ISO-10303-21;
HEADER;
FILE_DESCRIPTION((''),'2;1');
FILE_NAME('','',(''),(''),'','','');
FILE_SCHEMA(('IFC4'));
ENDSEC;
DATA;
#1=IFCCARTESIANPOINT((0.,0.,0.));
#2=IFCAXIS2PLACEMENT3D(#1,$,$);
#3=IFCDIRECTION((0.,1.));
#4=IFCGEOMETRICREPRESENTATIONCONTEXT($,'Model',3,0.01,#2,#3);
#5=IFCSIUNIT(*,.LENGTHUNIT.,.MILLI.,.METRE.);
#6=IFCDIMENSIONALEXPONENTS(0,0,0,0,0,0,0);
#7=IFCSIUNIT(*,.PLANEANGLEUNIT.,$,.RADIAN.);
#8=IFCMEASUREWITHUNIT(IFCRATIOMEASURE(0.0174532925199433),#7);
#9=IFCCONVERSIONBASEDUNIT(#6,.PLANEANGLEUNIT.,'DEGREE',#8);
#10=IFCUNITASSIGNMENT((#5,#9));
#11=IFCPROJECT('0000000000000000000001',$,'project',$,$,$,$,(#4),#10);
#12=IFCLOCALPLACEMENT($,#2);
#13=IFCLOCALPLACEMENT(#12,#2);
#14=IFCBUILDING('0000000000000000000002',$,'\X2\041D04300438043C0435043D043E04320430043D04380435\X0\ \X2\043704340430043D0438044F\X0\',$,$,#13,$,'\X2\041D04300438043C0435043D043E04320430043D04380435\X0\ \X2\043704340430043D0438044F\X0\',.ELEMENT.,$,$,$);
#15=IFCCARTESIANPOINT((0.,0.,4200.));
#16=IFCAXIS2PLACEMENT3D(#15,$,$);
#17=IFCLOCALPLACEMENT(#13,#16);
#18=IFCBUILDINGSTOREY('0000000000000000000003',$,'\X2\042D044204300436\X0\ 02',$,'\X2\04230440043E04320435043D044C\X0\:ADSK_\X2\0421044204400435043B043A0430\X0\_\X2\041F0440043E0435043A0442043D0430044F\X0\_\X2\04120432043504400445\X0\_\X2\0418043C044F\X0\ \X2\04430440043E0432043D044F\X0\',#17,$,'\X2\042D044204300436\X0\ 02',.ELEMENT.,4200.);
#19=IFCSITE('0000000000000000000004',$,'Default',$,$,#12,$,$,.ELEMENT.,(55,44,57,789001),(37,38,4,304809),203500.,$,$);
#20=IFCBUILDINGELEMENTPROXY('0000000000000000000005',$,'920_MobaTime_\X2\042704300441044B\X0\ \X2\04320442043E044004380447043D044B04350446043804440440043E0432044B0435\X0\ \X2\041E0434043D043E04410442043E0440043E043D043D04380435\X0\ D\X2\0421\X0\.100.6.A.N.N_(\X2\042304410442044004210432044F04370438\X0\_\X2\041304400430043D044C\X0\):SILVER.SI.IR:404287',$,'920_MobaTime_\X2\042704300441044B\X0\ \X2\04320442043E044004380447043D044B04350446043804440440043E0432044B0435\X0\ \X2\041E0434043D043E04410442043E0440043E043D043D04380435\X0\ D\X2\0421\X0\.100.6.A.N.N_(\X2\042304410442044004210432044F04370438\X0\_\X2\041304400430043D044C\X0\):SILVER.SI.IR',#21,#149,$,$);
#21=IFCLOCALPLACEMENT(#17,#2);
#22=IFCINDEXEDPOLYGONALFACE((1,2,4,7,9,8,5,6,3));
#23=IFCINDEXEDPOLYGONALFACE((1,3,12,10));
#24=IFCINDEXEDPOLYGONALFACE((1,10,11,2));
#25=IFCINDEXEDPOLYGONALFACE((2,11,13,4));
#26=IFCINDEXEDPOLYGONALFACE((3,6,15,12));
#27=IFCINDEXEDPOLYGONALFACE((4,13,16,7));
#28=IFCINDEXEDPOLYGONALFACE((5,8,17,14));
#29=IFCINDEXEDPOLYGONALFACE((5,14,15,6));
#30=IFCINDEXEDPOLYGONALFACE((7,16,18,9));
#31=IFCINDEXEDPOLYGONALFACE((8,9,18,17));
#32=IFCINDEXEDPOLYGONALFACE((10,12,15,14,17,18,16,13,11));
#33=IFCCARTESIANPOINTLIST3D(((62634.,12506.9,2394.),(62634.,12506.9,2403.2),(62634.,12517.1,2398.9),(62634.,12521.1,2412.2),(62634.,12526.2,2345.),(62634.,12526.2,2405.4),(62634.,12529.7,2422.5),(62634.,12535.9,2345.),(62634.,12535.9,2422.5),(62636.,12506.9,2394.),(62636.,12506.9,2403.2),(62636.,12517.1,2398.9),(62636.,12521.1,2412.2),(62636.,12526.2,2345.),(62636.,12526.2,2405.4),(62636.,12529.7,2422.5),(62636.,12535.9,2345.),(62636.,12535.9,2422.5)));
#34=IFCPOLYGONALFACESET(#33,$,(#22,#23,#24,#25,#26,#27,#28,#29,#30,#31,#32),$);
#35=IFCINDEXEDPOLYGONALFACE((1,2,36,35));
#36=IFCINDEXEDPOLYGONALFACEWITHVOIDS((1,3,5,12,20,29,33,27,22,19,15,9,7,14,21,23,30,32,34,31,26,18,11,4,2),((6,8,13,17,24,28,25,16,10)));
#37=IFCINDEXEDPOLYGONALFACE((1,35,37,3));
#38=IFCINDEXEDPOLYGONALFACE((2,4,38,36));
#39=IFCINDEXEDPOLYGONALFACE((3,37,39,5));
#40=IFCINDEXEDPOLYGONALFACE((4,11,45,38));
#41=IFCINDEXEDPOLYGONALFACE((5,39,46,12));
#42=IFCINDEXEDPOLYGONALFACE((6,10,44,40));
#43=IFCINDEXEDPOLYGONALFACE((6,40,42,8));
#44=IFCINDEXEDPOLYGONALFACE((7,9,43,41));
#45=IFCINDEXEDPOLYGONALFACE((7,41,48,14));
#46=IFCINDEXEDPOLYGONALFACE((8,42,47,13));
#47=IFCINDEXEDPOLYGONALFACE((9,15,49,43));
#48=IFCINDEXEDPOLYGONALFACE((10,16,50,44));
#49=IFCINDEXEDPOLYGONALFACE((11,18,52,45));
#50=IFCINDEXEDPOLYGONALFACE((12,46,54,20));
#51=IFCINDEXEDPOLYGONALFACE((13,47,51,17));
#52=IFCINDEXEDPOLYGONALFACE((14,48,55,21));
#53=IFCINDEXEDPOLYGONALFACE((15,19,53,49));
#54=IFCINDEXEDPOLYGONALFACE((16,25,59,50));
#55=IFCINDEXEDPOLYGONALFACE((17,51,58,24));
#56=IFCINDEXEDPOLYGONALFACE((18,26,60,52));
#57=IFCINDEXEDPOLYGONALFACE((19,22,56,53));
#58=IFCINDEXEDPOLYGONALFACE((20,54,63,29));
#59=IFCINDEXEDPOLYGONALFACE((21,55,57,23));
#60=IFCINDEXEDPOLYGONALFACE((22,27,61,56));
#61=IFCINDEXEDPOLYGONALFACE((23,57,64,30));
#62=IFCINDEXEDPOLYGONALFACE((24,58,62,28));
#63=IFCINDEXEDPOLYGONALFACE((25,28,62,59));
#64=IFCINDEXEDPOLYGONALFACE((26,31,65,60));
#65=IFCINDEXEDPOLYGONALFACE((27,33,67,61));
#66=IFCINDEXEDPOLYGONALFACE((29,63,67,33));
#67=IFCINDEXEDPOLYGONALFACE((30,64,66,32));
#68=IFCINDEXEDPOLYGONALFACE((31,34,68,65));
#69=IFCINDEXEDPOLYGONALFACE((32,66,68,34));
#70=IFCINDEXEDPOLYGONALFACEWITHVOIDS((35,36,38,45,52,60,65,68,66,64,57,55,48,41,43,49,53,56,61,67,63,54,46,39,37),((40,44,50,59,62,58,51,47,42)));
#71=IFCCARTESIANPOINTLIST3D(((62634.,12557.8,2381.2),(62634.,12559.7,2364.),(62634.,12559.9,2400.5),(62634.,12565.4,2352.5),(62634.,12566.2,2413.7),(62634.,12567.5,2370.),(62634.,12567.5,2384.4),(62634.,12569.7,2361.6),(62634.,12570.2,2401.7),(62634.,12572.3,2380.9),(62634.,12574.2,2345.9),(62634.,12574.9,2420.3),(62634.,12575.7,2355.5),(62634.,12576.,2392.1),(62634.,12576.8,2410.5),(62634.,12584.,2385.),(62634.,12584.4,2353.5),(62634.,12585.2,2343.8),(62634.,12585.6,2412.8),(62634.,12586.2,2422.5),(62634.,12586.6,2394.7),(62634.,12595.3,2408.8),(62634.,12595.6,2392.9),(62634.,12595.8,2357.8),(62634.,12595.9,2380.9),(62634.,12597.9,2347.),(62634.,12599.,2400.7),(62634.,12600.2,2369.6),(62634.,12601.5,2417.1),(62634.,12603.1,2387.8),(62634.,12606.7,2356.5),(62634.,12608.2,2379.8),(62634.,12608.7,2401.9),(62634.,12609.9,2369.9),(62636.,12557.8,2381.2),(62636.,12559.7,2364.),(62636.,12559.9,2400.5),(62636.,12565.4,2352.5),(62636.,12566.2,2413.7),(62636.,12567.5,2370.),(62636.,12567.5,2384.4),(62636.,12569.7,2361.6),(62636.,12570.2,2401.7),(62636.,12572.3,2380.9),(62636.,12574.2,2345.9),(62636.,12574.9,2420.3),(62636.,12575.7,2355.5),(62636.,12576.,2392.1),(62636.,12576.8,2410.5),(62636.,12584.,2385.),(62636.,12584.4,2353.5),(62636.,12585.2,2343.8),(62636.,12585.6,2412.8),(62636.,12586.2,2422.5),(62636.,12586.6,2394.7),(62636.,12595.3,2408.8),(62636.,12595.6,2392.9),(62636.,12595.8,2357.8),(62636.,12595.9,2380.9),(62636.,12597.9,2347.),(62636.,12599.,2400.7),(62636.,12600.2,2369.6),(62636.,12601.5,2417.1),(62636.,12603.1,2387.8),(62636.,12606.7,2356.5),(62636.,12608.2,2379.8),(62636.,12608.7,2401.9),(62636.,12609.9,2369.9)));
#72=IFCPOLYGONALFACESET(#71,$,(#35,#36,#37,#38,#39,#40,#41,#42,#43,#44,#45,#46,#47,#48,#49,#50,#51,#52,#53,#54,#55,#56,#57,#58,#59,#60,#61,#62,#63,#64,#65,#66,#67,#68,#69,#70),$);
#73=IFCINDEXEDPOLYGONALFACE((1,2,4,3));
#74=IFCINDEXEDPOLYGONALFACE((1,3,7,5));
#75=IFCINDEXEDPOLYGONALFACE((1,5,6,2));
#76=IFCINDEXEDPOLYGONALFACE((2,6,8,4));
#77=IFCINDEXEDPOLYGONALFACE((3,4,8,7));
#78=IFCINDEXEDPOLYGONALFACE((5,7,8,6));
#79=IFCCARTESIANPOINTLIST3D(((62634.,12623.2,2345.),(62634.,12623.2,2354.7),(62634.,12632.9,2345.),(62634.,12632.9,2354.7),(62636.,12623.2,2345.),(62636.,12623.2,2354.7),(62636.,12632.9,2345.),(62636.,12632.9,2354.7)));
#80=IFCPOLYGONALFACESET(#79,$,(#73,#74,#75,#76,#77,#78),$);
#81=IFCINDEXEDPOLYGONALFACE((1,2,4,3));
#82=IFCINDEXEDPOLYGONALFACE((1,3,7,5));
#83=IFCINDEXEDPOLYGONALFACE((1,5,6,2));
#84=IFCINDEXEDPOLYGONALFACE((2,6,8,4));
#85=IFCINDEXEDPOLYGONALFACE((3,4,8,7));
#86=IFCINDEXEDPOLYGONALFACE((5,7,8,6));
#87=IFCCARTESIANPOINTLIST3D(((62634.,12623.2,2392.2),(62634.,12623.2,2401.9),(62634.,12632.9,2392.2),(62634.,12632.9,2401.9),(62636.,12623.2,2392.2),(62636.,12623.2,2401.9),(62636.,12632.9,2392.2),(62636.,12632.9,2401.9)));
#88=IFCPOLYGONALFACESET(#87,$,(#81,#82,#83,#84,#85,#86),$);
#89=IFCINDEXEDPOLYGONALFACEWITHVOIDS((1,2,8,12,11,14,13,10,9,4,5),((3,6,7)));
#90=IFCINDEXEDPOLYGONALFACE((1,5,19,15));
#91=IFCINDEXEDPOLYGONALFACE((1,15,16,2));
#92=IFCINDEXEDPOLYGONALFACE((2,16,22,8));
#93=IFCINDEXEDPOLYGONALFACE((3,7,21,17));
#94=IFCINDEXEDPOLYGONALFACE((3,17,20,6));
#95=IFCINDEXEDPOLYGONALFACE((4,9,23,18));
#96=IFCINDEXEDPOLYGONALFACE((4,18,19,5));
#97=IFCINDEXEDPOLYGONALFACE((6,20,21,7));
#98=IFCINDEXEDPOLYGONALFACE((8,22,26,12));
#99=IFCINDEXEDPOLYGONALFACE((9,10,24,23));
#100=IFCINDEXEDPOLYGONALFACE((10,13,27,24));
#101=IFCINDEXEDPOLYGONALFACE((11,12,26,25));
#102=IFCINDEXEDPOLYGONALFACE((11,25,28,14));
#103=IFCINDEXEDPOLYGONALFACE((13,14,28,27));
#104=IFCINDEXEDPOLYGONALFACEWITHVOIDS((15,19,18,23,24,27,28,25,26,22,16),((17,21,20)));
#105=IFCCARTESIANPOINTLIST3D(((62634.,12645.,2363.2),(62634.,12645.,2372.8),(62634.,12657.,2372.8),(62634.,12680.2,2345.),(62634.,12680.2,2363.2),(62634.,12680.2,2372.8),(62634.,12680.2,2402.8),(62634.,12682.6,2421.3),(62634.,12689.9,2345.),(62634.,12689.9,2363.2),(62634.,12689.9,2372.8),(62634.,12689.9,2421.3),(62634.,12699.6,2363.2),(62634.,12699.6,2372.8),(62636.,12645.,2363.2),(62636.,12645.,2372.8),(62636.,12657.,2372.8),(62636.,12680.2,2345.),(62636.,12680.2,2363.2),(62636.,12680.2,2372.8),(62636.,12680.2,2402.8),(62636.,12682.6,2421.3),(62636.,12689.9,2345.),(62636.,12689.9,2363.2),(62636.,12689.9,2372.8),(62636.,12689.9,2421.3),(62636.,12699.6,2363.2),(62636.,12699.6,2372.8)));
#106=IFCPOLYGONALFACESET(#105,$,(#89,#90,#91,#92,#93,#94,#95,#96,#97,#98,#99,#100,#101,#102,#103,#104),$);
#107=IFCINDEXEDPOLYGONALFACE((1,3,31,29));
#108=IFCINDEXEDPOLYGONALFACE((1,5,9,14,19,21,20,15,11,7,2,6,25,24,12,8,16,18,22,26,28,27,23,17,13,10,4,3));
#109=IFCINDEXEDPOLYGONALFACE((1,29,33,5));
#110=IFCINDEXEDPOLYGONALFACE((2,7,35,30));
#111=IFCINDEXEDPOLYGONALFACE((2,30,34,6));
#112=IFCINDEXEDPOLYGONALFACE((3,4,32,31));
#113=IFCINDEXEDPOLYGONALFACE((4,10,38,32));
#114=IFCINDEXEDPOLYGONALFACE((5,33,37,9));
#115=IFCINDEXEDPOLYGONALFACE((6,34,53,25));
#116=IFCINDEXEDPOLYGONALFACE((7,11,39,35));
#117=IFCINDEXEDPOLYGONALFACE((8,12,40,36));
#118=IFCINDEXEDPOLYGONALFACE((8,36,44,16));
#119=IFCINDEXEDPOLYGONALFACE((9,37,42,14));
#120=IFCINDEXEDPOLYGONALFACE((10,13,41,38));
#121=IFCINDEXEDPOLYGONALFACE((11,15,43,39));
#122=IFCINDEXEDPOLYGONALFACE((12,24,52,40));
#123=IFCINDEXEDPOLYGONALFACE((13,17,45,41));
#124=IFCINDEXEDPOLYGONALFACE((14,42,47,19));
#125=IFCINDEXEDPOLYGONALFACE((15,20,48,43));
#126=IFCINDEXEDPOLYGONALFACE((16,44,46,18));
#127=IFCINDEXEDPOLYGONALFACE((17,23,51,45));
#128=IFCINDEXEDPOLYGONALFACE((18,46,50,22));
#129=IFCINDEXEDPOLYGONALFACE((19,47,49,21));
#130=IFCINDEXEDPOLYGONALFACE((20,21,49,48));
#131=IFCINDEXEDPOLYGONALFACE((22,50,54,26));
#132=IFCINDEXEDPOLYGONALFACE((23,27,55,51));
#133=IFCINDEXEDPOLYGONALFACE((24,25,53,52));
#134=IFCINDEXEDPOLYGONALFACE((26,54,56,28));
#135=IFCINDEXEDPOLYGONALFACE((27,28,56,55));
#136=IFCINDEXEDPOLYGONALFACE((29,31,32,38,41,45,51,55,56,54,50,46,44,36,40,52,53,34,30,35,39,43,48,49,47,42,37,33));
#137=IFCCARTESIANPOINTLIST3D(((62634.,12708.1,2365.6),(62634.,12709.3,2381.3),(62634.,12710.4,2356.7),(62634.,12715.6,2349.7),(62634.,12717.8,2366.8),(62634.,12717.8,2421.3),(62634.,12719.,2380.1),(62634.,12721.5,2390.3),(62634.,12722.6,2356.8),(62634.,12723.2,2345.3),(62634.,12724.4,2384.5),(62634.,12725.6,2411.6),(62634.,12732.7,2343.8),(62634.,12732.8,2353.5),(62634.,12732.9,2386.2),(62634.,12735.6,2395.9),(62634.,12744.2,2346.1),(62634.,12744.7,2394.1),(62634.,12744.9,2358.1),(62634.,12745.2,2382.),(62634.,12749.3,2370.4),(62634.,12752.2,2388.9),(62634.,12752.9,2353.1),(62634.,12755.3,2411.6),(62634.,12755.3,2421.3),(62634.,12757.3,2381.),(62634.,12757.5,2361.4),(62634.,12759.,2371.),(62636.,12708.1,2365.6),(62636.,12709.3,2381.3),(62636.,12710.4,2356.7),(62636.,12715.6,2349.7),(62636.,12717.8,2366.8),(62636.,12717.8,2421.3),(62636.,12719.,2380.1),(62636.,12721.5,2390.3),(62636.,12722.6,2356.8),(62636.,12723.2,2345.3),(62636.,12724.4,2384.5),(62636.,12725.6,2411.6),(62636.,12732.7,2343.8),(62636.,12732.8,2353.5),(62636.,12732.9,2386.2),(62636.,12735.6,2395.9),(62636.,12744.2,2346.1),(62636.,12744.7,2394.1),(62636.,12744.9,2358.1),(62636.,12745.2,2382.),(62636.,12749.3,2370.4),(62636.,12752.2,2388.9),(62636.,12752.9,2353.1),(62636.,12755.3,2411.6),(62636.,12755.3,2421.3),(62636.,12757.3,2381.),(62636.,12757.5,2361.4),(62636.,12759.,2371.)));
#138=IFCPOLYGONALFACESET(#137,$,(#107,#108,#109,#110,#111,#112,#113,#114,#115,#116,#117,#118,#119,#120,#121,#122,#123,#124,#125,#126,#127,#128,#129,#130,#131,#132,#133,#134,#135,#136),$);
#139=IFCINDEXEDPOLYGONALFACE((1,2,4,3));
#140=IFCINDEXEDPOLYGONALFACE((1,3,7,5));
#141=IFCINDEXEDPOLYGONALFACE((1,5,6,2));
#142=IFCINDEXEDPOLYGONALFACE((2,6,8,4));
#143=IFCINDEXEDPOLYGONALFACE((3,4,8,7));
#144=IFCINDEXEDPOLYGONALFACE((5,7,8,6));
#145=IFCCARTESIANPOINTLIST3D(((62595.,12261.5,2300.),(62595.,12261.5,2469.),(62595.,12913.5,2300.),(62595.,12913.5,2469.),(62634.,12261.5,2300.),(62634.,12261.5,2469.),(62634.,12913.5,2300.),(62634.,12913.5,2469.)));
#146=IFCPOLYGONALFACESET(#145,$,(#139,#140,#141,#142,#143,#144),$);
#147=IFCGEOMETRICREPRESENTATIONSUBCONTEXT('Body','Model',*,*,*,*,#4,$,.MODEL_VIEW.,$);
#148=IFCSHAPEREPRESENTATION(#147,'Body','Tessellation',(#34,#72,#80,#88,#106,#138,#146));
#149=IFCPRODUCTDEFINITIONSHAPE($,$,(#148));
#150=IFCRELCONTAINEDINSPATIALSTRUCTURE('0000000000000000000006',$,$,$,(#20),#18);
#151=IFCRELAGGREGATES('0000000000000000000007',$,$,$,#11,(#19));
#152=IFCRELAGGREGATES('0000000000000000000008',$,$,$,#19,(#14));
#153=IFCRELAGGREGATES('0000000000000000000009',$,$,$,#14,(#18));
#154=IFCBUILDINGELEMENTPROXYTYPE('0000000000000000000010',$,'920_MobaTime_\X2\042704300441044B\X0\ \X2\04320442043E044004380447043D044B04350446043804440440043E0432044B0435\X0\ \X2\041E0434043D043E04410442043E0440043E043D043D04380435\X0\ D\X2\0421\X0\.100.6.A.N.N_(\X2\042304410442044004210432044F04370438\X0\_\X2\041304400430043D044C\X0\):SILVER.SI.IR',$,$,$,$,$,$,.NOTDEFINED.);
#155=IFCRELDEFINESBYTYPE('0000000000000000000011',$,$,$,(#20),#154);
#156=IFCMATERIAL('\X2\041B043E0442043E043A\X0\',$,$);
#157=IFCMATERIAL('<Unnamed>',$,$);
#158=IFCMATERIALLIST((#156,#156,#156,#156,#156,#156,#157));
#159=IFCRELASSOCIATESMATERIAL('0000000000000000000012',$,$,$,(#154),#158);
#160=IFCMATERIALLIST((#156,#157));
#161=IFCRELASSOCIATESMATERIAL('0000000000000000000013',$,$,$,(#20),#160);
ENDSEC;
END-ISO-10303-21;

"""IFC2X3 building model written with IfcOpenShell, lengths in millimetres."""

from ifc_helpers import new_model, entity, si_unit, converted_unit, direction, frame, origin, origin_2d_with_axis, place, context, subcontext, project, spatial, polyline, rectangle, outline, extrude, source, transform, mapped, material, material_list, type_object, type_shapes, element, save


model = new_model("IFC2X3")

# Units and contexts
model_context = context("Model", 3, precision=0.01, world=origin(), true_north=direction((0.0, 1.0)))
body_context = subcontext(model_context, "Body", "Model", "MODEL_VIEW")
ifc_project = project(units=[si_unit("LENGTHUNIT", "METRE", prefix="MILLI"), converted_unit("PLANEANGLEUNIT", "DEGREE", entity("IfcRatioMeasure", 0.0174532925199433), si_unit("PLANEANGLEUNIT", "RADIAN"), dimensions=[0, 0, 0, 0, 0, 0, 0])], contexts=[model_context])

# Site, building, storey
site_placement = place(None, frame((0.0, 0.0, 0.0)))
site = spatial("IfcSite", under=ifc_project, at=site_placement, Name="Default", CompositionType="ELEMENT", RefLatitude=(55, 44, 57, 789001), RefLongitude=(37, 38, 4, 304809), RefElevation=203500.0)
building_placement = place(site_placement, origin())
building = spatial("IfcBuilding", under=site, at=building_placement, Name="Наименование здания", LongName="Наименование здания", CompositionType="ELEMENT")
storey_placement = place(building_placement, frame((0.0, 0.0, 4200.0)))
storey = spatial("IfcBuildingStorey", under=building, at=storey_placement, Name="Этаж 02", ObjectType="Уровень:ADSK_Стрелка_Проектная_Вверх_Имя уровня", LongName="Этаж 02", CompositionType="ELEMENT", Elevation=4200.0)

# Building element proxy
ifc_material_1 = material(Name="Лоток")
ifc_material_2 = material(Name="<Unnamed>")
ifc_material_list_1 = material_list([ifc_material_1, ifc_material_2])
ifc_material_list_2 = material_list([ifc_material_1, ifc_material_1, ifc_material_1, ifc_material_1, ifc_material_1, ifc_material_1, ifc_material_2])
building_element_proxy_type_1 = type_object("IfcBuildingElementProxyType", Name="920_MobaTime_Часы вторичныецифровые Односторонние DС.100.6.A.N.N_(УстрСвязи_Грань):SILVER.SI.IR", PredefinedType="NOTDEFINED", material=ifc_material_list_2)
shared_shape_1 = source(origin(), body_context, "Body", "SweptSolid", [
    extrude(outline(polyline([(-49.3, -13.1), (28.2, -13.1), (28.2, -6.8), (17.9, 1.8), (8.9, 16.0), (-0.3, 16.0), (4.6, 5.8), (11.1, -3.4), (-49.3, -3.4), (-49.3, -13.1)])), frame((-64.6, 9.8, 39.0), z_axis=(0.0, 0.0, 1.0), x_axis=(0.0, 1.0, 0.0)), (0.0, 0.0, 1.0), 2.0),
    extrude(outline(polyline([(2.2, -27.6), (19.0, -27.6), (30.5, -16.1), (33.3, -4.9), (31.0, 5.8), (21.8, 17.2), (5.2, 27.3), (-11.1, 33.0), (-24.0, 32.7), (-33.6, 27.6), (-40.3, 18.6), (-42.8, 5.7), (-38.0, -6.3), (-27.2, -15.0), (-17.5, -17.7), (-8.2, -16.4), (-0.3, -11.9), (5.1, -4.5), (7.3, 6.2), (4.0, 17.2), (18.5, 7.3), (23.6, -2.4), (22.0, -11.4), (14.2, -18.4), (5.3, -18.3), (2.2, -27.6)]), holes=[polyline([(-9.0, 23.3), (-1.3, 14.4), (-2.6, 2.0), (-11.4, -7.0), (-23.4, -6.1), (-32.2, 2.9), (-31.2, 15.1), (-25.6, 22.1), (-17.5, 24.9), (-9.0, 23.3)])]), frame((-2.7, 3.6, 39.0), z_axis=(0.0, 0.0, 1.0), x_axis=(-0.427649, 0.903945, 0.0)), (0.0, 0.0, 1.0), 2.0),
    extrude(rectangle(XDim=9.7, YDim=9.7, at=origin_2d_with_axis()), frame((40.6, -34.7, 39.0)), (0.0, 0.0, 1.0), 2.0),
    extrude(rectangle(XDim=9.7, YDim=9.7, at=origin_2d_with_axis()), frame((40.6, 12.6, 39.0)), (0.0, 0.0, 1.0), 2.0),
    extrude(outline(polyline([(-0.9, -28.1), (8.8, -28.1), (8.8, -9.9), (18.5, -9.9), (18.5, -0.2), (8.8, -0.2), (8.8, 48.3), (1.5, 48.3), (-36.0, -0.2), (-36.0, -9.9), (-0.9, -9.9), (-0.9, -28.1)]), holes=[polyline([(-0.9, -0.2), (-24.1, -0.2), (-0.9, 29.7), (-0.9, -0.2)])]), frame((93.6, -11.4, 39.0)), (0.0, 0.0, 1.0), 2.0),
    extrude(outline(polyline([(3.3, -28.3), (12.5, -28.3), (20.5, -25.0), (26.8, -18.8), (30.7, -10.0), (31.4, 1.6), (26.9, 11.8), (20.1, 18.4), (11.1, 22.3), (1.0, 23.3), (-7.9, 20.4), (-14.9, 14.5), (-18.9, 6.2), (-17.1, -9.0), (-36.7, 0.5), (-29.1, 29.3), (-38.5, 31.7), (-48.1, -4.6), (-11.6, -23.0), (-8.0, -14.0), (-10.8, -7.6), (-10.2, 1.1), (-3.0, 11.8), (9.2, 12.8), (20.0, 5.4), (21.3, -7.5), (15.5, -16.4), (4.6, -18.6), (3.3, -28.3)])), frame((147.1, -8.5, 39.0), z_axis=(0.0, 0.0, 1.0), x_axis=(0.256974, -0.966418, 0.0)), (0.0, 0.0, 1.0), 2.0),
    extrude(rectangle(XDim=652.0, YDim=169.0, at=origin_2d_with_axis()), frame((0.0, 0.0, 0.0), z_axis=(0.0, 0.0, 1.0), x_axis=(-1.0, 0.0, 0.0)), (0.0, 0.0, 1.0), 39.0),
])
type_shapes(building_element_proxy_type_1, [shared_shape_1])
proxy_1_placement = place(storey_placement, frame((62595.0, 12587.5, 2384.5), z_axis=(1.0, 0.0, 0.0), x_axis=(0.0, 1.0, 0.0)))
element("IfcBuildingElementProxy", 1, at=proxy_1_placement, inside=storey, type_object=building_element_proxy_type_1, material=ifc_material_list_1, Name="920_MobaTime_Часы вторичныецифровые Односторонние DС.100.6.A.N.N_(УстрСвязи_Грань):SILVER.SI.IR:404287", ObjectType="920_MobaTime_Часы вторичныецифровые Односторонние DС.100.6.A.N.N_(УстрСвязи_Грань):SILVER.SI.IR", context=body_context, shape_type="MappedRepresentation", body=[
    mapped(shared_shape_1, transform((0.0, 0.0, 0.0), scale=1.0)),
])

save(model, "model.ifc")
